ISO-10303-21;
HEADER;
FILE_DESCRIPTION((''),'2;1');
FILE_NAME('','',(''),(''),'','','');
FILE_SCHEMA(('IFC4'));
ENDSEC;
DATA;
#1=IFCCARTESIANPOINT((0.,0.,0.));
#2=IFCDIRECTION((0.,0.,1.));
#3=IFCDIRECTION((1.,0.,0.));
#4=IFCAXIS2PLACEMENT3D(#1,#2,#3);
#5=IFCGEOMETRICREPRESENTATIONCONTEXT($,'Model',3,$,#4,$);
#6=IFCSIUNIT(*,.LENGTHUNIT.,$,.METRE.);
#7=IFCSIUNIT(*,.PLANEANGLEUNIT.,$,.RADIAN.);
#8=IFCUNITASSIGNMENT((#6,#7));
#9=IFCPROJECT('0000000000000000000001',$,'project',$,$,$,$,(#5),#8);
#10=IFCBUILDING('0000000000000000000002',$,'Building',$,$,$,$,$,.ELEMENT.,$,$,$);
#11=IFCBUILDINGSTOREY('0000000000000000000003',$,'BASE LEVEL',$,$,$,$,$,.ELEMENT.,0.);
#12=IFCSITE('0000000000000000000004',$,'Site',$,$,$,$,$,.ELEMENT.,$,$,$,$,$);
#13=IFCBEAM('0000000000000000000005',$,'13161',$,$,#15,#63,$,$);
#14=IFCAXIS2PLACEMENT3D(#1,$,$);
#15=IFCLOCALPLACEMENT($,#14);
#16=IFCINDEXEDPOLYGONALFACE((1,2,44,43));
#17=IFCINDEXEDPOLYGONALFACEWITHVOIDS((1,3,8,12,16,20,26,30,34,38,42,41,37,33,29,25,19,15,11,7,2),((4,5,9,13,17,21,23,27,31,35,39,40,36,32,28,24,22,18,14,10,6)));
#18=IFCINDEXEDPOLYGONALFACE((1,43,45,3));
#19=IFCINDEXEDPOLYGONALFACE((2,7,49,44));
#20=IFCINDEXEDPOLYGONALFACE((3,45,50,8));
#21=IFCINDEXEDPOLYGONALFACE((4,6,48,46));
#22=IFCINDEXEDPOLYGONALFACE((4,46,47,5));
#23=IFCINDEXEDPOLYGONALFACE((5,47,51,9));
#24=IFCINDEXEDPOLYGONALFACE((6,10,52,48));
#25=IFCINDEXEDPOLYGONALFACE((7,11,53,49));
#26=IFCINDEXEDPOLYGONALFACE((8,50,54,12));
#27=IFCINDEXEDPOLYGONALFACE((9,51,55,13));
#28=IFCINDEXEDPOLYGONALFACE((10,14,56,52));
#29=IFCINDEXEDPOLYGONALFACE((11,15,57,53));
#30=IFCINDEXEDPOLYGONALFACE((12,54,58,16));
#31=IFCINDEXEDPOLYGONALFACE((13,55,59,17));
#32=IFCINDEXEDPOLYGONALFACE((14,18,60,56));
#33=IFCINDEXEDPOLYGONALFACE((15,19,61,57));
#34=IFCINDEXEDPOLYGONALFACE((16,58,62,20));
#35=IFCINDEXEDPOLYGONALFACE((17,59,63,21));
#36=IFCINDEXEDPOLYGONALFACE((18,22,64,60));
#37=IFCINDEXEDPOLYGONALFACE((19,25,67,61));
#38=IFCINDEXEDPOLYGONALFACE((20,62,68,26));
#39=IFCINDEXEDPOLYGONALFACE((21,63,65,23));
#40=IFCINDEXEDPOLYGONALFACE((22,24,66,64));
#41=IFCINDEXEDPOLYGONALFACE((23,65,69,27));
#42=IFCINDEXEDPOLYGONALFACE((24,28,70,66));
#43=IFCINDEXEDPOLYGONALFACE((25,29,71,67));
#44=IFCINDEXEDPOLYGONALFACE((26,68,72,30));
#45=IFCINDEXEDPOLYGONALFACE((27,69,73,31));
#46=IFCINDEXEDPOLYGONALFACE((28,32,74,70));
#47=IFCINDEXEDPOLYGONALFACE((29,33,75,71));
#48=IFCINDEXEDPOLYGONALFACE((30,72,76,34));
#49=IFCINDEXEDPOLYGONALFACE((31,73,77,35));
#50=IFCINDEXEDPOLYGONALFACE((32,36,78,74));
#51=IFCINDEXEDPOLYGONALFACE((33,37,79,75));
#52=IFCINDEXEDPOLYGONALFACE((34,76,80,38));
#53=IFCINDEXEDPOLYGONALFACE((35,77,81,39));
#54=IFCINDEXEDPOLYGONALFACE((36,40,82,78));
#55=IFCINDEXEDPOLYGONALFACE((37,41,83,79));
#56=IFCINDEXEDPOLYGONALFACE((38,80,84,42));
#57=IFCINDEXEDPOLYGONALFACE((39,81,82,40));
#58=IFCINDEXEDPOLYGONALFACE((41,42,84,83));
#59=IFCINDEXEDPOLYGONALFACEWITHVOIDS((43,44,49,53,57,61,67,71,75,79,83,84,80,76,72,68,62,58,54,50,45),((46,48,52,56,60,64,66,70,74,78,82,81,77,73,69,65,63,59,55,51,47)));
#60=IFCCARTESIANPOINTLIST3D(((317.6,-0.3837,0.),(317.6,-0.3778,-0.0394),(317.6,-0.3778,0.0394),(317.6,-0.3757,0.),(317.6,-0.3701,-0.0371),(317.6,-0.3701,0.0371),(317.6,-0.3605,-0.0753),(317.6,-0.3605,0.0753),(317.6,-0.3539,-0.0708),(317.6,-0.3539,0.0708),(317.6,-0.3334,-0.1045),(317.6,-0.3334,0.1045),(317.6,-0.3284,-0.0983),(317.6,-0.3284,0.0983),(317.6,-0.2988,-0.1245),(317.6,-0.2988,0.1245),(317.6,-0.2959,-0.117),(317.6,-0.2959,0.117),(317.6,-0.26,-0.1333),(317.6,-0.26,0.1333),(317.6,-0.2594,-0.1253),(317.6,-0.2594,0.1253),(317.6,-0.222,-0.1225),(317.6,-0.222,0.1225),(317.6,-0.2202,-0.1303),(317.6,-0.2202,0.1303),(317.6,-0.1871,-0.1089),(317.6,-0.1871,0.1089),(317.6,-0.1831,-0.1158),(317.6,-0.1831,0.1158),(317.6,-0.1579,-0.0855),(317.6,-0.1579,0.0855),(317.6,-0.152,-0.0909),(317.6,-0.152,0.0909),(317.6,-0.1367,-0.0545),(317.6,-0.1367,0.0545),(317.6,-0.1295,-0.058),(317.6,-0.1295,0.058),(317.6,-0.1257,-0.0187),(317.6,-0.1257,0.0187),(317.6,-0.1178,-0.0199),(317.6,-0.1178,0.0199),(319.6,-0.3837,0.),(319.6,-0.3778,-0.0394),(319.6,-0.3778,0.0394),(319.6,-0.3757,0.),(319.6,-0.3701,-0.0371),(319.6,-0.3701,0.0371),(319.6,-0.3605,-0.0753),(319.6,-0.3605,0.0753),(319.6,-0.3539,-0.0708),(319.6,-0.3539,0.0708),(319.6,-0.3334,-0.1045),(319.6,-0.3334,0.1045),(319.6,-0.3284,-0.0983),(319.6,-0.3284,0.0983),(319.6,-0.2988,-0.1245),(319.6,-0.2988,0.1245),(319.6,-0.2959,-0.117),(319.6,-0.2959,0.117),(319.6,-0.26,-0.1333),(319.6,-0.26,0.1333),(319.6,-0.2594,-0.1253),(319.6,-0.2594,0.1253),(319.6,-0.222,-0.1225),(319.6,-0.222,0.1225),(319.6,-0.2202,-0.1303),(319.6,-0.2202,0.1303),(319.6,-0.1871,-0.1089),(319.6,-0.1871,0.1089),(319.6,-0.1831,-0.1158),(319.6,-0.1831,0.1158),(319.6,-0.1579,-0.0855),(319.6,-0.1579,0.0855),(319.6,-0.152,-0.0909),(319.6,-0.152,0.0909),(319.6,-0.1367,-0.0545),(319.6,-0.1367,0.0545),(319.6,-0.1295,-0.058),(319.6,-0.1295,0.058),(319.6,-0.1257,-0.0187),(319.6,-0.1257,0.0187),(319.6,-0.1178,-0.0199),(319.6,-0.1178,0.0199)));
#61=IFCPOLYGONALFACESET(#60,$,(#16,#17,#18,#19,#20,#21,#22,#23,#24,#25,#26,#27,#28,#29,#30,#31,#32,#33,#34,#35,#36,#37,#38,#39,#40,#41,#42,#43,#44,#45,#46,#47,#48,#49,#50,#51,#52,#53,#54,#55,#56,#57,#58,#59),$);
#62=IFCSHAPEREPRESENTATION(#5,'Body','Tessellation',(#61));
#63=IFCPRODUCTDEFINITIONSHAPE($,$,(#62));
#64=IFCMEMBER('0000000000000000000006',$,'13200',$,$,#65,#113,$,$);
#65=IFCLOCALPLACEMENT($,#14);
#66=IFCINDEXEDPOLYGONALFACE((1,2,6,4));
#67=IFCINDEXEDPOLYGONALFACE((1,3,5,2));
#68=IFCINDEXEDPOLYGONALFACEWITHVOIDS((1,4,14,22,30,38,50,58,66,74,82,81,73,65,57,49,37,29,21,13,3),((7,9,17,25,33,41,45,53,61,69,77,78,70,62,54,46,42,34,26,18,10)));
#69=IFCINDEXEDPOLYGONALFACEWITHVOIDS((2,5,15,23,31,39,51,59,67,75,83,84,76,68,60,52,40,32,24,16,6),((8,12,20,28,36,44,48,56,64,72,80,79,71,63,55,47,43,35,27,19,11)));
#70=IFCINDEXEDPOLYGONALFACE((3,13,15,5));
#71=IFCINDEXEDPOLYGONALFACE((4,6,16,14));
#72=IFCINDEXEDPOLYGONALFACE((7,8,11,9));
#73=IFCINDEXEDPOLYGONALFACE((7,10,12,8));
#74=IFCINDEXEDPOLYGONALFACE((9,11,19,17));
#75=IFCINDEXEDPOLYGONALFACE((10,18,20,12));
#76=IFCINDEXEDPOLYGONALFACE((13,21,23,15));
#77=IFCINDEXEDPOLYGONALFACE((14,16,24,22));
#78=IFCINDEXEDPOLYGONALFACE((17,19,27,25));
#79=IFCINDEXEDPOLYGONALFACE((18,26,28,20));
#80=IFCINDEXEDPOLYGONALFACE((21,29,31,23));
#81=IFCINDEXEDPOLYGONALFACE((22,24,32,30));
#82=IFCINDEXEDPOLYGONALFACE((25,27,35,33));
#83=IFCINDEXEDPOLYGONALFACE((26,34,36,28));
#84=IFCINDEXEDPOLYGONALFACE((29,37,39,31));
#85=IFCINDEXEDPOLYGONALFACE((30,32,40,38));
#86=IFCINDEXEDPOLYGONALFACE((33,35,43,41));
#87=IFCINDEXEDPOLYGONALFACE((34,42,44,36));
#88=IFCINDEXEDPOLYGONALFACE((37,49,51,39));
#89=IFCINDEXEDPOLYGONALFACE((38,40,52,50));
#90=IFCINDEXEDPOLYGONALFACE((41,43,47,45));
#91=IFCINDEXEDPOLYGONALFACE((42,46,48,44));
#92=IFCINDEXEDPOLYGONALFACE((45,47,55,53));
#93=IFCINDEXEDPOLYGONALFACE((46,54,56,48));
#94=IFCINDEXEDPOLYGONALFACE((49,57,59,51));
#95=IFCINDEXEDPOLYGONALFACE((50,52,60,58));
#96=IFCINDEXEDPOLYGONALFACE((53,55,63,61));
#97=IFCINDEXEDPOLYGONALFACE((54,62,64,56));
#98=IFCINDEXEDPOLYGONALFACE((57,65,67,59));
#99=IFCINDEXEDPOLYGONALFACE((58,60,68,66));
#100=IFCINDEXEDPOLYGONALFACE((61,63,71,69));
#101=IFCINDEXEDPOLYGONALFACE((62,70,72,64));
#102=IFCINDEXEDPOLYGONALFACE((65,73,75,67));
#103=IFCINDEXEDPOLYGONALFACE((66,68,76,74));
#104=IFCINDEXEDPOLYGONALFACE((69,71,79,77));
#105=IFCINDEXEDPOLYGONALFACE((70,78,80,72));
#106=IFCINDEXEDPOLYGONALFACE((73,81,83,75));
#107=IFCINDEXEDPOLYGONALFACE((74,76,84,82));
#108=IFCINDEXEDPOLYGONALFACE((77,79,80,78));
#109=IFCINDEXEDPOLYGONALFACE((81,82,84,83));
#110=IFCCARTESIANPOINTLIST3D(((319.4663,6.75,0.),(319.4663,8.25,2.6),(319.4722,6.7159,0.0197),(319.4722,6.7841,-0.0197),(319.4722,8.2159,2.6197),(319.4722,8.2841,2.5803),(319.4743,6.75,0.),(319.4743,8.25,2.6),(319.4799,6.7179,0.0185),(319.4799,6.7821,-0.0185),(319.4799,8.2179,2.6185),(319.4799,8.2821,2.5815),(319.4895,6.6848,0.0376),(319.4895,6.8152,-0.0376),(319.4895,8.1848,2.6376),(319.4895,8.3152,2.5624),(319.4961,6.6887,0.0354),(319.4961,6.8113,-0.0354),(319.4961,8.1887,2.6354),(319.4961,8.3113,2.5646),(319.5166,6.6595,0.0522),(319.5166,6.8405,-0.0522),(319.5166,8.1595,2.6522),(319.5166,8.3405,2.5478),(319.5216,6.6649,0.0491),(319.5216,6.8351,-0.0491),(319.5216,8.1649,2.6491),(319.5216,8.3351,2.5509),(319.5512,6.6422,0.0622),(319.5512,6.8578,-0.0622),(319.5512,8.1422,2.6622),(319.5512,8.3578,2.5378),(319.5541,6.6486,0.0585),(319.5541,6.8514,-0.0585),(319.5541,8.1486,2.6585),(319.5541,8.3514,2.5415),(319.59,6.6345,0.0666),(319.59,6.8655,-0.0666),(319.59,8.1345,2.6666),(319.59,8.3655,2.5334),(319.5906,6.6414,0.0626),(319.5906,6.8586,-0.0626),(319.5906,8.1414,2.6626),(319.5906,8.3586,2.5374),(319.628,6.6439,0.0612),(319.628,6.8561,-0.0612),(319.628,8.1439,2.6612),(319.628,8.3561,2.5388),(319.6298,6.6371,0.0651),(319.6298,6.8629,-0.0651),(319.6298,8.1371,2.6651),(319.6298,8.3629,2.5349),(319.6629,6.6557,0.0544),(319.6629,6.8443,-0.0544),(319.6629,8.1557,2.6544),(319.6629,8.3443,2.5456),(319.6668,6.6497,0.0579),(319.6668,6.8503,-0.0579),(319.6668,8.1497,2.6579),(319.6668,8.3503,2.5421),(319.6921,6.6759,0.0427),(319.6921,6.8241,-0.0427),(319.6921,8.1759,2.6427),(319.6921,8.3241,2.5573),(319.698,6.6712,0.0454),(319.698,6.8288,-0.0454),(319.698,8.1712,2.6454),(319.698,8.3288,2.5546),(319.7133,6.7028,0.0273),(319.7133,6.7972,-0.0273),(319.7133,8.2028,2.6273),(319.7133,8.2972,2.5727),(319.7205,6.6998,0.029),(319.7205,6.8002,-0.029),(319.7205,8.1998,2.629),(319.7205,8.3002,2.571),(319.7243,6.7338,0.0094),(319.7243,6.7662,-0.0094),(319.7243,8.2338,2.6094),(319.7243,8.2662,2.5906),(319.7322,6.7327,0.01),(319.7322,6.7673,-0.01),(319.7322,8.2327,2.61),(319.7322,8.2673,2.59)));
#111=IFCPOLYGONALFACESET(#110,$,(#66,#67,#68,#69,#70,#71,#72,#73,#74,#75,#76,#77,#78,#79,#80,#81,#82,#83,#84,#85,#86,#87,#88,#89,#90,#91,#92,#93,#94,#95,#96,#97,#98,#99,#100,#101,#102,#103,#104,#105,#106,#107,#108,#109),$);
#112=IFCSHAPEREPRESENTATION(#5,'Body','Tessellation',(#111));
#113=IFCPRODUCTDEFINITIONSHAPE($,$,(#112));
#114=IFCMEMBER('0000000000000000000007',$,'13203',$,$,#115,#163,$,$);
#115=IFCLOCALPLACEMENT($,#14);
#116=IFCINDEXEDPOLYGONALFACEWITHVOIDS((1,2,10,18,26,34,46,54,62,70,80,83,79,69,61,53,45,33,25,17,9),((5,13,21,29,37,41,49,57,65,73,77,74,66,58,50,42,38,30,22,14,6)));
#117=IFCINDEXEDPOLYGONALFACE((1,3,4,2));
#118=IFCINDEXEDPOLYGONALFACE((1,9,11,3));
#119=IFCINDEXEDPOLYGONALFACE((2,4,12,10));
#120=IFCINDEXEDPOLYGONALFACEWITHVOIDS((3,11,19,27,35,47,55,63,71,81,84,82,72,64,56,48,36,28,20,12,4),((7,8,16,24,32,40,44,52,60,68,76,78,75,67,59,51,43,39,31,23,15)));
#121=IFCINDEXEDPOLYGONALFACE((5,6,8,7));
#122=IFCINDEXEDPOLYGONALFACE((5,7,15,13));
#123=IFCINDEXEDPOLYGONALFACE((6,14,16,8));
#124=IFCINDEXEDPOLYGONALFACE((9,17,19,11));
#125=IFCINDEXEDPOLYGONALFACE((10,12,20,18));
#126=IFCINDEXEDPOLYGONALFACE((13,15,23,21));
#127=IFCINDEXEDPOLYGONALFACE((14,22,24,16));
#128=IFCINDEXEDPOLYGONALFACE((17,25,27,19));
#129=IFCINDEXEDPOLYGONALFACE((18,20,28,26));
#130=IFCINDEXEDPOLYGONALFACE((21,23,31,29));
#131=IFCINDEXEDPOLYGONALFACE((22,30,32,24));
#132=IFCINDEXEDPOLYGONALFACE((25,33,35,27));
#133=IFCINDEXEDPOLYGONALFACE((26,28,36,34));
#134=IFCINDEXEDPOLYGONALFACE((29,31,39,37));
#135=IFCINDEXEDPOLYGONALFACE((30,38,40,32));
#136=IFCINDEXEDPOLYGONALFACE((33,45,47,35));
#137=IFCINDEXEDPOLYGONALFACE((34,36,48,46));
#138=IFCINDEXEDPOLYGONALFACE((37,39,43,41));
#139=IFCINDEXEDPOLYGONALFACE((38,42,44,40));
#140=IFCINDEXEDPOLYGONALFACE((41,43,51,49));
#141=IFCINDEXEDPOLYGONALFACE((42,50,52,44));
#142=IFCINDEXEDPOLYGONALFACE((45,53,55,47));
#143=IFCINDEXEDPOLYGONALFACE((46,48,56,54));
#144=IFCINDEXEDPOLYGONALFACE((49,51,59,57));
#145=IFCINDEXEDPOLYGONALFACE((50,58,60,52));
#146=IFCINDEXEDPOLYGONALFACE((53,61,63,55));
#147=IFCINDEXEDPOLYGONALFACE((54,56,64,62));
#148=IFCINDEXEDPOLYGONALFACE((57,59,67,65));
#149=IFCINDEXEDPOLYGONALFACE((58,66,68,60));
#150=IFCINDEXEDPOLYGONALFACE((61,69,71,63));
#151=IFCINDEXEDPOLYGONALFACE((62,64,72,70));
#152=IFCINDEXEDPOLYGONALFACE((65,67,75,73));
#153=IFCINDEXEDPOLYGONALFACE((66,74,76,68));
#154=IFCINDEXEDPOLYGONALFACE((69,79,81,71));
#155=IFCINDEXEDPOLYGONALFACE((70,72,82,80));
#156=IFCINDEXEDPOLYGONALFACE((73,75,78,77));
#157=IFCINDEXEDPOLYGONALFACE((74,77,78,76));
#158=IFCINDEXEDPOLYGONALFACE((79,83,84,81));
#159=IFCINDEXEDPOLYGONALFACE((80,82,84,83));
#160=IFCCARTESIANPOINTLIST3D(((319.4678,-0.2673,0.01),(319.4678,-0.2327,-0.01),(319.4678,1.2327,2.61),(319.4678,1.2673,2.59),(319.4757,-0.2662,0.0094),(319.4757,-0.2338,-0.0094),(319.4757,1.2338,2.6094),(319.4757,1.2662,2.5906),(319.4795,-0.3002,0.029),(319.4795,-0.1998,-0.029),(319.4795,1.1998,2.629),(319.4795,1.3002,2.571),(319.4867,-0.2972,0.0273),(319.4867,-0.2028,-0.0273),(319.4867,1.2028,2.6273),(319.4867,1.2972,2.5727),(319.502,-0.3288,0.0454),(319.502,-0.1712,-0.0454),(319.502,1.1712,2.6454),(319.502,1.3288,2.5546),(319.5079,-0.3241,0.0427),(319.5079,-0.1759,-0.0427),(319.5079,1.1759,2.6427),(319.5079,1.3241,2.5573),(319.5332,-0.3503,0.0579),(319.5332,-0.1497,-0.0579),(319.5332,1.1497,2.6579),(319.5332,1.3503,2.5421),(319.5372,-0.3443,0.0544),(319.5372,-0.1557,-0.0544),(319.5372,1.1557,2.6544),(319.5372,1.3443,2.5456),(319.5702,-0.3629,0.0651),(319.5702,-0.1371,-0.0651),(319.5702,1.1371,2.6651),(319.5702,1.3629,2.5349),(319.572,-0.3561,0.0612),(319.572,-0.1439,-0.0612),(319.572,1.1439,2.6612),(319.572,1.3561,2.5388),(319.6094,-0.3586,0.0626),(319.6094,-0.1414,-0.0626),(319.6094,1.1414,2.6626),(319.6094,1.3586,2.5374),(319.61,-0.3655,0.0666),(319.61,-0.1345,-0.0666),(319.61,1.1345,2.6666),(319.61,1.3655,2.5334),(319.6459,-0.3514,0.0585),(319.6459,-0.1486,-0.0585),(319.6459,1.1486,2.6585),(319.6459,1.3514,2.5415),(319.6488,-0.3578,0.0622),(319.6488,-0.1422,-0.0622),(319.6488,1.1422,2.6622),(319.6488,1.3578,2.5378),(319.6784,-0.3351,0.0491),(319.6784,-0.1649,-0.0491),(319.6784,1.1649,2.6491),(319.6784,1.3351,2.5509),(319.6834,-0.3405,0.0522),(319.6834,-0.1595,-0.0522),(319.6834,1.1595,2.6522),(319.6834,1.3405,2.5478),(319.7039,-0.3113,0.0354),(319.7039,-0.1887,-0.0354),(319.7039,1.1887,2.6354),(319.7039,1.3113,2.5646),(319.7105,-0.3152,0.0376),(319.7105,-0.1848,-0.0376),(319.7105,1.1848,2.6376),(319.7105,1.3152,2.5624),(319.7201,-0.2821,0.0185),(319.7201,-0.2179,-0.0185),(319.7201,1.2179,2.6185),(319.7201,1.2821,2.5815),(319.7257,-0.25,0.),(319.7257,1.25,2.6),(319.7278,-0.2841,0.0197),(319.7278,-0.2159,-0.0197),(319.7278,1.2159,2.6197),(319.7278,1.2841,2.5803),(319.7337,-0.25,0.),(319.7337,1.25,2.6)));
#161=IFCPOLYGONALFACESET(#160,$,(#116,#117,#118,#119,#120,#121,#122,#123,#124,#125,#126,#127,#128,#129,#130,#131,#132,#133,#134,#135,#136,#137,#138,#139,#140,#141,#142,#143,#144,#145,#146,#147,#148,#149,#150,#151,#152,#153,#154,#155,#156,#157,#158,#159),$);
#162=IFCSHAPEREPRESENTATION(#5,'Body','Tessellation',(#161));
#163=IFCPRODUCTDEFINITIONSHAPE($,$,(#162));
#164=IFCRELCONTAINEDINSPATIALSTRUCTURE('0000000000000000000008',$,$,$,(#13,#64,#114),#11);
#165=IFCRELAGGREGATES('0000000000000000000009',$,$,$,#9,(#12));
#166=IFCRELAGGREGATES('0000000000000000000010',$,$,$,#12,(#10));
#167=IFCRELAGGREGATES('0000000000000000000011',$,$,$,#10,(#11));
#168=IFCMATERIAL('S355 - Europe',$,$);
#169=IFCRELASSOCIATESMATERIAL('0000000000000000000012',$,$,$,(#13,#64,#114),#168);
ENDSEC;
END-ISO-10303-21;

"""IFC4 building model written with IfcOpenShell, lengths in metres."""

from ifc_helpers import new_model, si_unit, frame, origin_with_axes, origin_2d_with_axis, place, context, project, spatial, hollow_circle, extrude, material, material_profile, profile_set, profile_usage, element, save


model = new_model("IFC4")

# Units and contexts
model_context = context("Model", 3, world=origin_with_axes())
ifc_project = project(units=[si_unit("LENGTHUNIT", "METRE"), si_unit("PLANEANGLEUNIT", "RADIAN")], contexts=[model_context])

# Site, building, storey
site = spatial("IfcSite", under=ifc_project, Name="Site", CompositionType="ELEMENT")
building = spatial("IfcBuilding", under=site, Name="Building", CompositionType="ELEMENT")
storey = spatial("IfcBuildingStorey", under=building, Name="BASE LEVEL", CompositionType="ELEMENT", Elevation=0.0)

# Shared definitions
ifc_material = material(Name="S355 - Europe")

# Beam
ifc_material_profile_1 = material_profile(ifc_material, hollow_circle(Radius=0.1337, WallThickness=0.008, at=origin_2d_with_axis()))
ifc_profile_set_1 = profile_set([ifc_material_profile_1])
ifc_profile_usage_1 = profile_usage(ifc_profile_set_1, cardinal=10)
beam_1_placement = place(None, frame((319.6, -0.25, 0.0), z_axis=(-1.0, 0.0, 0.0), x_axis=(0.0, -1.0, 0.0)))
element("IfcBeam", 1, at=beam_1_placement, inside=storey, material=ifc_profile_usage_1, Name="13161", context=model_context, shape_type="SweptSolid", body=[
    extrude(hollow_circle(Radius=0.1337, WallThickness=0.008, at=origin_2d_with_axis()), origin_with_axes(), (0.0, 0.0, 1.0), 2.0),
])

# Members
ifc_material_profile_2 = material_profile(ifc_material, hollow_circle(Radius=0.1337, WallThickness=0.008, at=origin_2d_with_axis()))
ifc_profile_set_2 = profile_set([ifc_material_profile_2])
ifc_profile_usage_2 = profile_usage(ifc_profile_set_2, cardinal=10)
member_1_placement = place(None, frame((319.6, 6.75, 0.0), z_axis=(0.0, 0.499722, 0.866186), x_axis=(-1.0, 0.0, 0.0)))
element("IfcMember", 2, at=member_1_placement, inside=storey, material=ifc_profile_usage_2, Name="13200", context=model_context, shape_type="SweptSolid", body=[
    extrude(hollow_circle(Radius=0.1337, WallThickness=0.008, at=origin_2d_with_axis()), origin_with_axes(), (0.0, 0.0, 1.0), 3.0017),
])
ifc_material_profile_3 = material_profile(ifc_material, hollow_circle(Radius=0.1337, WallThickness=0.008, at=origin_2d_with_axis()))
ifc_profile_set_3 = profile_set([ifc_material_profile_3])
ifc_profile_usage_3 = profile_usage(ifc_profile_set_3, cardinal=10)
member_2_placement = place(None, frame((319.6, 1.25, 2.6), z_axis=(0.0, -0.499722, -0.866186), x_axis=(1.0, 0.0, 0.0)))
element("IfcMember", 3, at=member_2_placement, inside=storey, material=ifc_profile_usage_3, Name="13203", context=model_context, shape_type="SweptSolid", body=[
    extrude(hollow_circle(Radius=0.1337, WallThickness=0.008, at=origin_2d_with_axis()), origin_with_axes(), (0.0, 0.0, 1.0), 3.0017),
])

save(model, "model.ifc")
